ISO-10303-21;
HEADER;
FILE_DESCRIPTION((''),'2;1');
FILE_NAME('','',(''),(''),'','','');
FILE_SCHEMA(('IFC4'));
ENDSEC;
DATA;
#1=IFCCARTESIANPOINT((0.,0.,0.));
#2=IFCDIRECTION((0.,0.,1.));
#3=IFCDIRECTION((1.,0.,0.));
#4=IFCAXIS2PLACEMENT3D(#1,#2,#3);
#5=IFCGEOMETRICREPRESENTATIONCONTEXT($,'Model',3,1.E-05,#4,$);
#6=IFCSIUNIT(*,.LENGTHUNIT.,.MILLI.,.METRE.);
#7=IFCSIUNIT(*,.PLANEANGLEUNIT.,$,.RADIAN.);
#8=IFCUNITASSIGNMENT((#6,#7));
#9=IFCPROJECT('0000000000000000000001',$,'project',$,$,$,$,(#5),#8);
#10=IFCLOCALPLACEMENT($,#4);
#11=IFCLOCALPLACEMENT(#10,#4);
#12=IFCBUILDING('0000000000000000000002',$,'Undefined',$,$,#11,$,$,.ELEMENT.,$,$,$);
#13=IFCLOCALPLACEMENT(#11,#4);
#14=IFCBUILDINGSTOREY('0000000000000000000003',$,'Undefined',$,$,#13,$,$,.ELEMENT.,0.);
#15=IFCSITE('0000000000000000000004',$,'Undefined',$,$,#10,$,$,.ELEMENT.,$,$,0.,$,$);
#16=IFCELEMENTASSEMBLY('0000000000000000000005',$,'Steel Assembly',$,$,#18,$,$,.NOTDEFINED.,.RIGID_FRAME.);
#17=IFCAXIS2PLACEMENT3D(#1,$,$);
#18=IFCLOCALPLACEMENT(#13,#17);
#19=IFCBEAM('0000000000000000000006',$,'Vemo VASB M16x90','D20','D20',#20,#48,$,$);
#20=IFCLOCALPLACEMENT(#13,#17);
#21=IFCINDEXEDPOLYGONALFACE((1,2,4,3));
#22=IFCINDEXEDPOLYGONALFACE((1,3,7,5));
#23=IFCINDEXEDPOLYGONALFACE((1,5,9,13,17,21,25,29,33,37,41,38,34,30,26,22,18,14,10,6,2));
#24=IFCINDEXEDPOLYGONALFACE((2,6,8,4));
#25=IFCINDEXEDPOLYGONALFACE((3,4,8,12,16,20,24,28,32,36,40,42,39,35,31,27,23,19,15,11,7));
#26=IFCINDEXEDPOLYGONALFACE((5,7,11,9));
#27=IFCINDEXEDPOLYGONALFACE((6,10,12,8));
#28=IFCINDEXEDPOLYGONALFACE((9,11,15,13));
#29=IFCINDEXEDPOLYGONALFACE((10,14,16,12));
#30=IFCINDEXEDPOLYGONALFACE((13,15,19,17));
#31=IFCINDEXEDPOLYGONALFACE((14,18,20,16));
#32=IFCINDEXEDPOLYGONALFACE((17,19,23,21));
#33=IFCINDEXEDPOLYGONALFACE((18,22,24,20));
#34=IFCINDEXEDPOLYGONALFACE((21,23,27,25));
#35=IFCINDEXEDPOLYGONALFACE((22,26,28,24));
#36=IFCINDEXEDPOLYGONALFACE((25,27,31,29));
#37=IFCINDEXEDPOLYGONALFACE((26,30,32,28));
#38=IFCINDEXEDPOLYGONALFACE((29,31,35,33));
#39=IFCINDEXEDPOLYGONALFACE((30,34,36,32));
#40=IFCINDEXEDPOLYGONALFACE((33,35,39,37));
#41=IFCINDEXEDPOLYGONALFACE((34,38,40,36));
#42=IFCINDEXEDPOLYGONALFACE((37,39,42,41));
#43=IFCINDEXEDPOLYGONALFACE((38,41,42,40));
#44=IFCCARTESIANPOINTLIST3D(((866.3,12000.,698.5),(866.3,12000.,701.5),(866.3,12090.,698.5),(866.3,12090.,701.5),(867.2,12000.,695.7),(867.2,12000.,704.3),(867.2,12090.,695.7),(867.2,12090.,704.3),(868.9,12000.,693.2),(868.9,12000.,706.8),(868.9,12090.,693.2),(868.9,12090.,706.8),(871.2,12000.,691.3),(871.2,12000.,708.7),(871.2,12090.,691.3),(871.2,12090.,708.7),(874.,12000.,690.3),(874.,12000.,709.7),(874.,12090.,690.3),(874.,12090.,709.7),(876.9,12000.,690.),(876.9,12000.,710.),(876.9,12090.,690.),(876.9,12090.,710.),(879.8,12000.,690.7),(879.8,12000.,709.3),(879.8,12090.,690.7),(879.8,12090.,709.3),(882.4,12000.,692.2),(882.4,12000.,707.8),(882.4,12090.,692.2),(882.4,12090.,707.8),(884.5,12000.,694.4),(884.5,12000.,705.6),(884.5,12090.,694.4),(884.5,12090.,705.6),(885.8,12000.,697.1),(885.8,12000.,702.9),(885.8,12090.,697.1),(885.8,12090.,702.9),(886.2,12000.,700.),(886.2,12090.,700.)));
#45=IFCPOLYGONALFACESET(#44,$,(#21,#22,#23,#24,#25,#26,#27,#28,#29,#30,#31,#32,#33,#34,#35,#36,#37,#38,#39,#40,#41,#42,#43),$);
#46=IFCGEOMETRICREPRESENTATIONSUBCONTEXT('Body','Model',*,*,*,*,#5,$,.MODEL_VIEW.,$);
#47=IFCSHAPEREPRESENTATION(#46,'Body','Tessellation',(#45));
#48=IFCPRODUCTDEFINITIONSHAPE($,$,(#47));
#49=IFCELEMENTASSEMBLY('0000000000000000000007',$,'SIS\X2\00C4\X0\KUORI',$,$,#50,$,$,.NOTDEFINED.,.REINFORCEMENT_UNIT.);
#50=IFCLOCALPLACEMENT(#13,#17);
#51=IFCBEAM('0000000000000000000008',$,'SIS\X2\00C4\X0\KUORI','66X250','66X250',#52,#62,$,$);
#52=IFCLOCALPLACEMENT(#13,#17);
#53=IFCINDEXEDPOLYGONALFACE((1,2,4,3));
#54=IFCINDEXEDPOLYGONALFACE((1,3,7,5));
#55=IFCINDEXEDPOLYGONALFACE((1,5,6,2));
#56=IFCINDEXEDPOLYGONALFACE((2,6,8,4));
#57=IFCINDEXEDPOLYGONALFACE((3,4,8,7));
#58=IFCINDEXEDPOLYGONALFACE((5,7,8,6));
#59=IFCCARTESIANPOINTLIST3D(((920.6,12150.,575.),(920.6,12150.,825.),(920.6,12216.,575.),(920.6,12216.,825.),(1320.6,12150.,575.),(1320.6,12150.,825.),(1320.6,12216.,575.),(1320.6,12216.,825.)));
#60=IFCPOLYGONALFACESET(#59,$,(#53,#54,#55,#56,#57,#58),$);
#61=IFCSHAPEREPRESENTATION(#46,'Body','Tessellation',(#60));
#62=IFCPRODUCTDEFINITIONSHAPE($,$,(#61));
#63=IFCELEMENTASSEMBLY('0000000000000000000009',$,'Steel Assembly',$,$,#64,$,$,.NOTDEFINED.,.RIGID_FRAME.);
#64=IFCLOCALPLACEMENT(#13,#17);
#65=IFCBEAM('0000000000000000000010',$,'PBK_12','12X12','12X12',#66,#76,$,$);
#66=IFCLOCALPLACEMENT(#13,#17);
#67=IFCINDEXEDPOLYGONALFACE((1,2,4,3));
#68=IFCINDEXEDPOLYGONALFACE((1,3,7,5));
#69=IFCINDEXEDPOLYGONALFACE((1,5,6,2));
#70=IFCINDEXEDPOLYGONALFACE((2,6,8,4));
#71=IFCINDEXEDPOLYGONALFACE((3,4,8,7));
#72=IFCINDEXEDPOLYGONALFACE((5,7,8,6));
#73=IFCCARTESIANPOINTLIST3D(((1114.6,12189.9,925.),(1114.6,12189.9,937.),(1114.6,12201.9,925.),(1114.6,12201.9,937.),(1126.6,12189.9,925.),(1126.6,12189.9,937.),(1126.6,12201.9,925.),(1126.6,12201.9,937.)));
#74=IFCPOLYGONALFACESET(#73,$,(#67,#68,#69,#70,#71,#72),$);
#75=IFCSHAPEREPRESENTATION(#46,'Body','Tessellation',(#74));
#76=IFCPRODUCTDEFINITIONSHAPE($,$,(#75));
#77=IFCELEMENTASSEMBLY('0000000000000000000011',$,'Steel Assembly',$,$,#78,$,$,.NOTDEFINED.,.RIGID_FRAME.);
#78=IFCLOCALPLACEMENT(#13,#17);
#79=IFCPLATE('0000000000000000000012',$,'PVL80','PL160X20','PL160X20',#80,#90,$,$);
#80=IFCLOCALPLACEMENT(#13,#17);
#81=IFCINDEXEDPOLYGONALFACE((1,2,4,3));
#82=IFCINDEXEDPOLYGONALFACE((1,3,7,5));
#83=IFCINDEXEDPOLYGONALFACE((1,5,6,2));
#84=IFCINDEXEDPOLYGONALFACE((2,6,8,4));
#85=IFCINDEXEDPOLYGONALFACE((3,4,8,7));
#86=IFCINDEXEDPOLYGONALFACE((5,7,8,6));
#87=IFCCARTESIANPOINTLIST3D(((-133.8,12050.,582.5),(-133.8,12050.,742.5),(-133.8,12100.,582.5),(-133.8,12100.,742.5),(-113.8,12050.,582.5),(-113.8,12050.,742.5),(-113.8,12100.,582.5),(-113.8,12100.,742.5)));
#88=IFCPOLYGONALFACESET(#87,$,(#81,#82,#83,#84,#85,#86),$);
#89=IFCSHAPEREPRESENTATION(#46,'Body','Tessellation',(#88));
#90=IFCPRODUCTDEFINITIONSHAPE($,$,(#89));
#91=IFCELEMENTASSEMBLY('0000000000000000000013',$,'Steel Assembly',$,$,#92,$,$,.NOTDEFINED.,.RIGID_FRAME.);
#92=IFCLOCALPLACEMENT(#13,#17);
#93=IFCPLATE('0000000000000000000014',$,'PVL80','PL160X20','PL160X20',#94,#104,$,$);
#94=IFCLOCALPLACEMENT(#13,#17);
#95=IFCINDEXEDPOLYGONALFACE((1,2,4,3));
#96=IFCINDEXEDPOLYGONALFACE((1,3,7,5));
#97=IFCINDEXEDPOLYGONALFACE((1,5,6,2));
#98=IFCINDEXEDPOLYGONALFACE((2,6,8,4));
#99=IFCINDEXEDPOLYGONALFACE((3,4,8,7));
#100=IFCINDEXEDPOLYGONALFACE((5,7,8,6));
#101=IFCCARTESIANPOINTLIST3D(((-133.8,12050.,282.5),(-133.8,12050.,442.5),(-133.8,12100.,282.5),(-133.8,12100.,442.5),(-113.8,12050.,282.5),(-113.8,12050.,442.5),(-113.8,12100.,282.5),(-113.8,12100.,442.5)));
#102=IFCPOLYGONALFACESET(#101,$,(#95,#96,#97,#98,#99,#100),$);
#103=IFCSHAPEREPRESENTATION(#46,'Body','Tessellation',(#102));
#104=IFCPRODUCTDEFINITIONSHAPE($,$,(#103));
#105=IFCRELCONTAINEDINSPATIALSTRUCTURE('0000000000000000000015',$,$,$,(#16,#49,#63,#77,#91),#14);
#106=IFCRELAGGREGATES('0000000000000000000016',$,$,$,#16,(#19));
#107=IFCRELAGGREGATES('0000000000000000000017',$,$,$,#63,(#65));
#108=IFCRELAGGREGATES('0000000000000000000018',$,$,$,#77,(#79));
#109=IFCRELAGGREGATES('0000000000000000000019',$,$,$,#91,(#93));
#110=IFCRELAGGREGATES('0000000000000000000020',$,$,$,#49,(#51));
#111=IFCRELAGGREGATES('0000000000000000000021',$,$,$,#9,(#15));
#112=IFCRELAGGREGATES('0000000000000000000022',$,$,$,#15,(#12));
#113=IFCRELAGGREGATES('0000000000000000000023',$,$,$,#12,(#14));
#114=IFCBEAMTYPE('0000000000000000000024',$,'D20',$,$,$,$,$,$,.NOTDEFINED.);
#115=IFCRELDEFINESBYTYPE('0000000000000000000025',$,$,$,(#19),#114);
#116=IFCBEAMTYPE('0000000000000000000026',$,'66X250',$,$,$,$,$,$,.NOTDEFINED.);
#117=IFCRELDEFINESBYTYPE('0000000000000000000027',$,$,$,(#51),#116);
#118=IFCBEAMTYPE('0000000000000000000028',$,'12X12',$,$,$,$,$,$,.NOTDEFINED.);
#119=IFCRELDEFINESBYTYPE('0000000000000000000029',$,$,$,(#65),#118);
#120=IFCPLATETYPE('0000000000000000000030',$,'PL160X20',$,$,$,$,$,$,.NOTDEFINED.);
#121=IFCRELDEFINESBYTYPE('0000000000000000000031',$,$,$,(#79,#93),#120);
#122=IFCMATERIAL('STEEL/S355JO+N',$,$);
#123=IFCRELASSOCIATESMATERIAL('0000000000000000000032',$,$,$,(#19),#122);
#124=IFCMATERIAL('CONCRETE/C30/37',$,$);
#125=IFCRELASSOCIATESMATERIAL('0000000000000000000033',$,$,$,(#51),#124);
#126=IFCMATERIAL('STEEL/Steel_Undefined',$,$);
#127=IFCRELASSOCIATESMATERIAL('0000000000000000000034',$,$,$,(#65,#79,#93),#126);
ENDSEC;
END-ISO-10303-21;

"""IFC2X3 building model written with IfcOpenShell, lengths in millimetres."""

from ifc_helpers import new_model, si_unit, frame, origin_with_axes, origin_2d_with_axis, place, context, subcontext, project, spatial, polyline, rectangle, circle, outline, extrude, material, type_object, element, aggregate, save


model = new_model("IFC2X3")

# Units and contexts
model_context = context("Model", 3, precision=1e-05, world=origin_with_axes())
body_context = subcontext(model_context, "Body", "Model", "MODEL_VIEW")
ifc_project = project(units=[si_unit("LENGTHUNIT", "METRE", prefix="MILLI"), si_unit("PLANEANGLEUNIT", "RADIAN")], contexts=[model_context])

# Site, building, storey
site_placement = place(None, origin_with_axes())
site = spatial("IfcSite", under=ifc_project, at=site_placement, Name="Undefined", CompositionType="ELEMENT", RefElevation=0.0)
building_placement = place(site_placement, origin_with_axes())
building = spatial("IfcBuilding", under=site, at=building_placement, Name="Undefined", CompositionType="ELEMENT")
storey_placement = place(building_placement, origin_with_axes())
storey = spatial("IfcBuildingStorey", under=building, at=storey_placement, Name="Undefined", CompositionType="ELEMENT", Elevation=0.0)

# Element assemblies, beams
assembly_1_placement = place(storey_placement, origin_with_axes())
assembly_1 = element("IfcElementAssembly", 1, at=assembly_1_placement, inside=storey, Name="Steel Assembly", AssemblyPlace="NOTDEFINED", PredefinedType="RIGID_FRAME")
ifc_material_1 = material(Name="STEEL/S355JO+N")
beam_type_1 = type_object("IfcBeamType", Name="D20", PredefinedType="NOTDEFINED")
beam_1_placement = place(assembly_1_placement, frame((876.2, 12000.0, 700.0), z_axis=(0.0, 0.0, 1.0), x_axis=(0.0, 1.0, 0.0)))
beam_1 = element("IfcBeam", 2, at=beam_1_placement, type_object=beam_type_1, material=ifc_material_1, Name="Vemo VASB M16x90", Description="D20", ObjectType="D20", context=body_context, shape_type="SweptSolid", body=[
    extrude(circle(Radius=10.0, at=origin_2d_with_axis()), frame((90.0, 0.0, 0.0), z_axis=(-1.0, 0.0, 0.0), x_axis=(0.0, -1.0, 0.0)), (0.0, 0.0, 1.0), 90.0),
])
assembly_2_placement = place(storey_placement, origin_with_axes())
assembly_2 = element("IfcElementAssembly", 3, at=assembly_2_placement, inside=storey, Name="SISÄKUORI", AssemblyPlace="NOTDEFINED", PredefinedType="REINFORCEMENT_UNIT")
ifc_material_2 = material(Name="CONCRETE/C30/37")
beam_type_2 = type_object("IfcBeamType", Name="66X250", PredefinedType="NOTDEFINED")
beam_2_placement = place(assembly_2_placement, frame((920.6, 12183.0, 700.0), z_axis=(0.0, -1.0, 0.0), x_axis=(1.0, 0.0, 0.0)))
beam_2 = element("IfcBeam", 4, at=beam_2_placement, type_object=beam_type_2, material=ifc_material_2, Name="SISÄKUORI", Description="66X250", ObjectType="66X250", context=body_context, shape_type="SweptSolid", body=[
    extrude(rectangle(XDim=250.0, YDim=66.0, at=origin_2d_with_axis()), frame((400.0, 0.0, 0.0), z_axis=(-1.0, 0.0, 0.0), x_axis=(0.0, -1.0, 0.0)), (0.0, 0.0, 1.0), 400.0),
])
assembly_3_placement = place(storey_placement, origin_with_axes())
assembly_3 = element("IfcElementAssembly", 5, at=assembly_3_placement, inside=storey, Name="Steel Assembly", AssemblyPlace="NOTDEFINED", PredefinedType="RIGID_FRAME")
ifc_material_3 = material(Name="STEEL/Steel_Undefined")
beam_type_3 = type_object("IfcBeamType", Name="12X12", PredefinedType="NOTDEFINED")
beam_3_placement = place(assembly_3_placement, frame((1126.6, 12195.9, 931.0), z_axis=(0.0, 0.0, 1.0), x_axis=(-1.0, 0.0, 0.0)))
beam_3 = element("IfcBeam", 6, at=beam_3_placement, type_object=beam_type_3, material=ifc_material_3, Name="PBK_12", Description="12X12", ObjectType="12X12", context=body_context, shape_type="SweptSolid", body=[
    extrude(rectangle(XDim=12.0, YDim=12.0, at=origin_2d_with_axis()), frame((12.0, 0.0, 0.0), z_axis=(-1.0, 0.0, 0.0), x_axis=(0.0, -1.0, 0.0)), (0.0, 0.0, 1.0), 12.0),
])

# Element assemblies, plates
assembly_4_placement = place(storey_placement, origin_with_axes())
assembly_4 = element("IfcElementAssembly", 7, at=assembly_4_placement, inside=storey, Name="Steel Assembly", AssemblyPlace="NOTDEFINED", PredefinedType="RIGID_FRAME")
plate_type = type_object("IfcPlateType", Name="PL160X20", PredefinedType="NOTDEFINED")
plate_1_placement = place(assembly_4_placement, frame((-133.8, 12050.0, 662.5), z_axis=(0.0, 0.0, -1.0), x_axis=(0.0, 1.0, 0.0)))
plate_1 = element("IfcPlate", 8, at=plate_1_placement, type_object=plate_type, material=ifc_material_3, Name="PVL80", Description="PL160X20", ObjectType="PL160X20", context=body_context, shape_type="SweptSolid", body=[
    extrude(outline(polyline([(0.0, 0.0), (50.0, 0.0), (50.0, 20.0), (0.0, 20.0), (0.0, 0.0)])), frame((0.0, 0.0, -80.0), z_axis=(0.0, 0.0, 1.0), x_axis=(1.0, 0.0, 0.0)), (0.0, 0.0, 1.0), 160.0),
])
assembly_5_placement = place(storey_placement, origin_with_axes())
assembly_5 = element("IfcElementAssembly", 9, at=assembly_5_placement, inside=storey, Name="Steel Assembly", AssemblyPlace="NOTDEFINED", PredefinedType="RIGID_FRAME")
plate_2_placement = place(assembly_5_placement, frame((-133.8, 12050.0, 362.5), z_axis=(0.0, 0.0, -1.0), x_axis=(0.0, 1.0, 0.0)))
plate_2 = element("IfcPlate", 10, at=plate_2_placement, type_object=plate_type, material=ifc_material_3, Name="PVL80", Description="PL160X20", ObjectType="PL160X20", context=body_context, shape_type="SweptSolid", body=[
    extrude(outline(polyline([(0.0, 0.0), (50.0, 0.0), (50.0, 20.0), (0.0, 20.0), (0.0, 0.0)])), frame((0.0, 0.0, -80.0), z_axis=(0.0, 0.0, 1.0), x_axis=(1.0, 0.0, 0.0)), (0.0, 0.0, 1.0), 160.0),
])

aggregate(assembly_1, [beam_1])

aggregate(assembly_3, [beam_3])
aggregate(assembly_4, [plate_1])
aggregate(assembly_5, [plate_2])
aggregate(assembly_2, [beam_2])

save(model, "model.ifc")
